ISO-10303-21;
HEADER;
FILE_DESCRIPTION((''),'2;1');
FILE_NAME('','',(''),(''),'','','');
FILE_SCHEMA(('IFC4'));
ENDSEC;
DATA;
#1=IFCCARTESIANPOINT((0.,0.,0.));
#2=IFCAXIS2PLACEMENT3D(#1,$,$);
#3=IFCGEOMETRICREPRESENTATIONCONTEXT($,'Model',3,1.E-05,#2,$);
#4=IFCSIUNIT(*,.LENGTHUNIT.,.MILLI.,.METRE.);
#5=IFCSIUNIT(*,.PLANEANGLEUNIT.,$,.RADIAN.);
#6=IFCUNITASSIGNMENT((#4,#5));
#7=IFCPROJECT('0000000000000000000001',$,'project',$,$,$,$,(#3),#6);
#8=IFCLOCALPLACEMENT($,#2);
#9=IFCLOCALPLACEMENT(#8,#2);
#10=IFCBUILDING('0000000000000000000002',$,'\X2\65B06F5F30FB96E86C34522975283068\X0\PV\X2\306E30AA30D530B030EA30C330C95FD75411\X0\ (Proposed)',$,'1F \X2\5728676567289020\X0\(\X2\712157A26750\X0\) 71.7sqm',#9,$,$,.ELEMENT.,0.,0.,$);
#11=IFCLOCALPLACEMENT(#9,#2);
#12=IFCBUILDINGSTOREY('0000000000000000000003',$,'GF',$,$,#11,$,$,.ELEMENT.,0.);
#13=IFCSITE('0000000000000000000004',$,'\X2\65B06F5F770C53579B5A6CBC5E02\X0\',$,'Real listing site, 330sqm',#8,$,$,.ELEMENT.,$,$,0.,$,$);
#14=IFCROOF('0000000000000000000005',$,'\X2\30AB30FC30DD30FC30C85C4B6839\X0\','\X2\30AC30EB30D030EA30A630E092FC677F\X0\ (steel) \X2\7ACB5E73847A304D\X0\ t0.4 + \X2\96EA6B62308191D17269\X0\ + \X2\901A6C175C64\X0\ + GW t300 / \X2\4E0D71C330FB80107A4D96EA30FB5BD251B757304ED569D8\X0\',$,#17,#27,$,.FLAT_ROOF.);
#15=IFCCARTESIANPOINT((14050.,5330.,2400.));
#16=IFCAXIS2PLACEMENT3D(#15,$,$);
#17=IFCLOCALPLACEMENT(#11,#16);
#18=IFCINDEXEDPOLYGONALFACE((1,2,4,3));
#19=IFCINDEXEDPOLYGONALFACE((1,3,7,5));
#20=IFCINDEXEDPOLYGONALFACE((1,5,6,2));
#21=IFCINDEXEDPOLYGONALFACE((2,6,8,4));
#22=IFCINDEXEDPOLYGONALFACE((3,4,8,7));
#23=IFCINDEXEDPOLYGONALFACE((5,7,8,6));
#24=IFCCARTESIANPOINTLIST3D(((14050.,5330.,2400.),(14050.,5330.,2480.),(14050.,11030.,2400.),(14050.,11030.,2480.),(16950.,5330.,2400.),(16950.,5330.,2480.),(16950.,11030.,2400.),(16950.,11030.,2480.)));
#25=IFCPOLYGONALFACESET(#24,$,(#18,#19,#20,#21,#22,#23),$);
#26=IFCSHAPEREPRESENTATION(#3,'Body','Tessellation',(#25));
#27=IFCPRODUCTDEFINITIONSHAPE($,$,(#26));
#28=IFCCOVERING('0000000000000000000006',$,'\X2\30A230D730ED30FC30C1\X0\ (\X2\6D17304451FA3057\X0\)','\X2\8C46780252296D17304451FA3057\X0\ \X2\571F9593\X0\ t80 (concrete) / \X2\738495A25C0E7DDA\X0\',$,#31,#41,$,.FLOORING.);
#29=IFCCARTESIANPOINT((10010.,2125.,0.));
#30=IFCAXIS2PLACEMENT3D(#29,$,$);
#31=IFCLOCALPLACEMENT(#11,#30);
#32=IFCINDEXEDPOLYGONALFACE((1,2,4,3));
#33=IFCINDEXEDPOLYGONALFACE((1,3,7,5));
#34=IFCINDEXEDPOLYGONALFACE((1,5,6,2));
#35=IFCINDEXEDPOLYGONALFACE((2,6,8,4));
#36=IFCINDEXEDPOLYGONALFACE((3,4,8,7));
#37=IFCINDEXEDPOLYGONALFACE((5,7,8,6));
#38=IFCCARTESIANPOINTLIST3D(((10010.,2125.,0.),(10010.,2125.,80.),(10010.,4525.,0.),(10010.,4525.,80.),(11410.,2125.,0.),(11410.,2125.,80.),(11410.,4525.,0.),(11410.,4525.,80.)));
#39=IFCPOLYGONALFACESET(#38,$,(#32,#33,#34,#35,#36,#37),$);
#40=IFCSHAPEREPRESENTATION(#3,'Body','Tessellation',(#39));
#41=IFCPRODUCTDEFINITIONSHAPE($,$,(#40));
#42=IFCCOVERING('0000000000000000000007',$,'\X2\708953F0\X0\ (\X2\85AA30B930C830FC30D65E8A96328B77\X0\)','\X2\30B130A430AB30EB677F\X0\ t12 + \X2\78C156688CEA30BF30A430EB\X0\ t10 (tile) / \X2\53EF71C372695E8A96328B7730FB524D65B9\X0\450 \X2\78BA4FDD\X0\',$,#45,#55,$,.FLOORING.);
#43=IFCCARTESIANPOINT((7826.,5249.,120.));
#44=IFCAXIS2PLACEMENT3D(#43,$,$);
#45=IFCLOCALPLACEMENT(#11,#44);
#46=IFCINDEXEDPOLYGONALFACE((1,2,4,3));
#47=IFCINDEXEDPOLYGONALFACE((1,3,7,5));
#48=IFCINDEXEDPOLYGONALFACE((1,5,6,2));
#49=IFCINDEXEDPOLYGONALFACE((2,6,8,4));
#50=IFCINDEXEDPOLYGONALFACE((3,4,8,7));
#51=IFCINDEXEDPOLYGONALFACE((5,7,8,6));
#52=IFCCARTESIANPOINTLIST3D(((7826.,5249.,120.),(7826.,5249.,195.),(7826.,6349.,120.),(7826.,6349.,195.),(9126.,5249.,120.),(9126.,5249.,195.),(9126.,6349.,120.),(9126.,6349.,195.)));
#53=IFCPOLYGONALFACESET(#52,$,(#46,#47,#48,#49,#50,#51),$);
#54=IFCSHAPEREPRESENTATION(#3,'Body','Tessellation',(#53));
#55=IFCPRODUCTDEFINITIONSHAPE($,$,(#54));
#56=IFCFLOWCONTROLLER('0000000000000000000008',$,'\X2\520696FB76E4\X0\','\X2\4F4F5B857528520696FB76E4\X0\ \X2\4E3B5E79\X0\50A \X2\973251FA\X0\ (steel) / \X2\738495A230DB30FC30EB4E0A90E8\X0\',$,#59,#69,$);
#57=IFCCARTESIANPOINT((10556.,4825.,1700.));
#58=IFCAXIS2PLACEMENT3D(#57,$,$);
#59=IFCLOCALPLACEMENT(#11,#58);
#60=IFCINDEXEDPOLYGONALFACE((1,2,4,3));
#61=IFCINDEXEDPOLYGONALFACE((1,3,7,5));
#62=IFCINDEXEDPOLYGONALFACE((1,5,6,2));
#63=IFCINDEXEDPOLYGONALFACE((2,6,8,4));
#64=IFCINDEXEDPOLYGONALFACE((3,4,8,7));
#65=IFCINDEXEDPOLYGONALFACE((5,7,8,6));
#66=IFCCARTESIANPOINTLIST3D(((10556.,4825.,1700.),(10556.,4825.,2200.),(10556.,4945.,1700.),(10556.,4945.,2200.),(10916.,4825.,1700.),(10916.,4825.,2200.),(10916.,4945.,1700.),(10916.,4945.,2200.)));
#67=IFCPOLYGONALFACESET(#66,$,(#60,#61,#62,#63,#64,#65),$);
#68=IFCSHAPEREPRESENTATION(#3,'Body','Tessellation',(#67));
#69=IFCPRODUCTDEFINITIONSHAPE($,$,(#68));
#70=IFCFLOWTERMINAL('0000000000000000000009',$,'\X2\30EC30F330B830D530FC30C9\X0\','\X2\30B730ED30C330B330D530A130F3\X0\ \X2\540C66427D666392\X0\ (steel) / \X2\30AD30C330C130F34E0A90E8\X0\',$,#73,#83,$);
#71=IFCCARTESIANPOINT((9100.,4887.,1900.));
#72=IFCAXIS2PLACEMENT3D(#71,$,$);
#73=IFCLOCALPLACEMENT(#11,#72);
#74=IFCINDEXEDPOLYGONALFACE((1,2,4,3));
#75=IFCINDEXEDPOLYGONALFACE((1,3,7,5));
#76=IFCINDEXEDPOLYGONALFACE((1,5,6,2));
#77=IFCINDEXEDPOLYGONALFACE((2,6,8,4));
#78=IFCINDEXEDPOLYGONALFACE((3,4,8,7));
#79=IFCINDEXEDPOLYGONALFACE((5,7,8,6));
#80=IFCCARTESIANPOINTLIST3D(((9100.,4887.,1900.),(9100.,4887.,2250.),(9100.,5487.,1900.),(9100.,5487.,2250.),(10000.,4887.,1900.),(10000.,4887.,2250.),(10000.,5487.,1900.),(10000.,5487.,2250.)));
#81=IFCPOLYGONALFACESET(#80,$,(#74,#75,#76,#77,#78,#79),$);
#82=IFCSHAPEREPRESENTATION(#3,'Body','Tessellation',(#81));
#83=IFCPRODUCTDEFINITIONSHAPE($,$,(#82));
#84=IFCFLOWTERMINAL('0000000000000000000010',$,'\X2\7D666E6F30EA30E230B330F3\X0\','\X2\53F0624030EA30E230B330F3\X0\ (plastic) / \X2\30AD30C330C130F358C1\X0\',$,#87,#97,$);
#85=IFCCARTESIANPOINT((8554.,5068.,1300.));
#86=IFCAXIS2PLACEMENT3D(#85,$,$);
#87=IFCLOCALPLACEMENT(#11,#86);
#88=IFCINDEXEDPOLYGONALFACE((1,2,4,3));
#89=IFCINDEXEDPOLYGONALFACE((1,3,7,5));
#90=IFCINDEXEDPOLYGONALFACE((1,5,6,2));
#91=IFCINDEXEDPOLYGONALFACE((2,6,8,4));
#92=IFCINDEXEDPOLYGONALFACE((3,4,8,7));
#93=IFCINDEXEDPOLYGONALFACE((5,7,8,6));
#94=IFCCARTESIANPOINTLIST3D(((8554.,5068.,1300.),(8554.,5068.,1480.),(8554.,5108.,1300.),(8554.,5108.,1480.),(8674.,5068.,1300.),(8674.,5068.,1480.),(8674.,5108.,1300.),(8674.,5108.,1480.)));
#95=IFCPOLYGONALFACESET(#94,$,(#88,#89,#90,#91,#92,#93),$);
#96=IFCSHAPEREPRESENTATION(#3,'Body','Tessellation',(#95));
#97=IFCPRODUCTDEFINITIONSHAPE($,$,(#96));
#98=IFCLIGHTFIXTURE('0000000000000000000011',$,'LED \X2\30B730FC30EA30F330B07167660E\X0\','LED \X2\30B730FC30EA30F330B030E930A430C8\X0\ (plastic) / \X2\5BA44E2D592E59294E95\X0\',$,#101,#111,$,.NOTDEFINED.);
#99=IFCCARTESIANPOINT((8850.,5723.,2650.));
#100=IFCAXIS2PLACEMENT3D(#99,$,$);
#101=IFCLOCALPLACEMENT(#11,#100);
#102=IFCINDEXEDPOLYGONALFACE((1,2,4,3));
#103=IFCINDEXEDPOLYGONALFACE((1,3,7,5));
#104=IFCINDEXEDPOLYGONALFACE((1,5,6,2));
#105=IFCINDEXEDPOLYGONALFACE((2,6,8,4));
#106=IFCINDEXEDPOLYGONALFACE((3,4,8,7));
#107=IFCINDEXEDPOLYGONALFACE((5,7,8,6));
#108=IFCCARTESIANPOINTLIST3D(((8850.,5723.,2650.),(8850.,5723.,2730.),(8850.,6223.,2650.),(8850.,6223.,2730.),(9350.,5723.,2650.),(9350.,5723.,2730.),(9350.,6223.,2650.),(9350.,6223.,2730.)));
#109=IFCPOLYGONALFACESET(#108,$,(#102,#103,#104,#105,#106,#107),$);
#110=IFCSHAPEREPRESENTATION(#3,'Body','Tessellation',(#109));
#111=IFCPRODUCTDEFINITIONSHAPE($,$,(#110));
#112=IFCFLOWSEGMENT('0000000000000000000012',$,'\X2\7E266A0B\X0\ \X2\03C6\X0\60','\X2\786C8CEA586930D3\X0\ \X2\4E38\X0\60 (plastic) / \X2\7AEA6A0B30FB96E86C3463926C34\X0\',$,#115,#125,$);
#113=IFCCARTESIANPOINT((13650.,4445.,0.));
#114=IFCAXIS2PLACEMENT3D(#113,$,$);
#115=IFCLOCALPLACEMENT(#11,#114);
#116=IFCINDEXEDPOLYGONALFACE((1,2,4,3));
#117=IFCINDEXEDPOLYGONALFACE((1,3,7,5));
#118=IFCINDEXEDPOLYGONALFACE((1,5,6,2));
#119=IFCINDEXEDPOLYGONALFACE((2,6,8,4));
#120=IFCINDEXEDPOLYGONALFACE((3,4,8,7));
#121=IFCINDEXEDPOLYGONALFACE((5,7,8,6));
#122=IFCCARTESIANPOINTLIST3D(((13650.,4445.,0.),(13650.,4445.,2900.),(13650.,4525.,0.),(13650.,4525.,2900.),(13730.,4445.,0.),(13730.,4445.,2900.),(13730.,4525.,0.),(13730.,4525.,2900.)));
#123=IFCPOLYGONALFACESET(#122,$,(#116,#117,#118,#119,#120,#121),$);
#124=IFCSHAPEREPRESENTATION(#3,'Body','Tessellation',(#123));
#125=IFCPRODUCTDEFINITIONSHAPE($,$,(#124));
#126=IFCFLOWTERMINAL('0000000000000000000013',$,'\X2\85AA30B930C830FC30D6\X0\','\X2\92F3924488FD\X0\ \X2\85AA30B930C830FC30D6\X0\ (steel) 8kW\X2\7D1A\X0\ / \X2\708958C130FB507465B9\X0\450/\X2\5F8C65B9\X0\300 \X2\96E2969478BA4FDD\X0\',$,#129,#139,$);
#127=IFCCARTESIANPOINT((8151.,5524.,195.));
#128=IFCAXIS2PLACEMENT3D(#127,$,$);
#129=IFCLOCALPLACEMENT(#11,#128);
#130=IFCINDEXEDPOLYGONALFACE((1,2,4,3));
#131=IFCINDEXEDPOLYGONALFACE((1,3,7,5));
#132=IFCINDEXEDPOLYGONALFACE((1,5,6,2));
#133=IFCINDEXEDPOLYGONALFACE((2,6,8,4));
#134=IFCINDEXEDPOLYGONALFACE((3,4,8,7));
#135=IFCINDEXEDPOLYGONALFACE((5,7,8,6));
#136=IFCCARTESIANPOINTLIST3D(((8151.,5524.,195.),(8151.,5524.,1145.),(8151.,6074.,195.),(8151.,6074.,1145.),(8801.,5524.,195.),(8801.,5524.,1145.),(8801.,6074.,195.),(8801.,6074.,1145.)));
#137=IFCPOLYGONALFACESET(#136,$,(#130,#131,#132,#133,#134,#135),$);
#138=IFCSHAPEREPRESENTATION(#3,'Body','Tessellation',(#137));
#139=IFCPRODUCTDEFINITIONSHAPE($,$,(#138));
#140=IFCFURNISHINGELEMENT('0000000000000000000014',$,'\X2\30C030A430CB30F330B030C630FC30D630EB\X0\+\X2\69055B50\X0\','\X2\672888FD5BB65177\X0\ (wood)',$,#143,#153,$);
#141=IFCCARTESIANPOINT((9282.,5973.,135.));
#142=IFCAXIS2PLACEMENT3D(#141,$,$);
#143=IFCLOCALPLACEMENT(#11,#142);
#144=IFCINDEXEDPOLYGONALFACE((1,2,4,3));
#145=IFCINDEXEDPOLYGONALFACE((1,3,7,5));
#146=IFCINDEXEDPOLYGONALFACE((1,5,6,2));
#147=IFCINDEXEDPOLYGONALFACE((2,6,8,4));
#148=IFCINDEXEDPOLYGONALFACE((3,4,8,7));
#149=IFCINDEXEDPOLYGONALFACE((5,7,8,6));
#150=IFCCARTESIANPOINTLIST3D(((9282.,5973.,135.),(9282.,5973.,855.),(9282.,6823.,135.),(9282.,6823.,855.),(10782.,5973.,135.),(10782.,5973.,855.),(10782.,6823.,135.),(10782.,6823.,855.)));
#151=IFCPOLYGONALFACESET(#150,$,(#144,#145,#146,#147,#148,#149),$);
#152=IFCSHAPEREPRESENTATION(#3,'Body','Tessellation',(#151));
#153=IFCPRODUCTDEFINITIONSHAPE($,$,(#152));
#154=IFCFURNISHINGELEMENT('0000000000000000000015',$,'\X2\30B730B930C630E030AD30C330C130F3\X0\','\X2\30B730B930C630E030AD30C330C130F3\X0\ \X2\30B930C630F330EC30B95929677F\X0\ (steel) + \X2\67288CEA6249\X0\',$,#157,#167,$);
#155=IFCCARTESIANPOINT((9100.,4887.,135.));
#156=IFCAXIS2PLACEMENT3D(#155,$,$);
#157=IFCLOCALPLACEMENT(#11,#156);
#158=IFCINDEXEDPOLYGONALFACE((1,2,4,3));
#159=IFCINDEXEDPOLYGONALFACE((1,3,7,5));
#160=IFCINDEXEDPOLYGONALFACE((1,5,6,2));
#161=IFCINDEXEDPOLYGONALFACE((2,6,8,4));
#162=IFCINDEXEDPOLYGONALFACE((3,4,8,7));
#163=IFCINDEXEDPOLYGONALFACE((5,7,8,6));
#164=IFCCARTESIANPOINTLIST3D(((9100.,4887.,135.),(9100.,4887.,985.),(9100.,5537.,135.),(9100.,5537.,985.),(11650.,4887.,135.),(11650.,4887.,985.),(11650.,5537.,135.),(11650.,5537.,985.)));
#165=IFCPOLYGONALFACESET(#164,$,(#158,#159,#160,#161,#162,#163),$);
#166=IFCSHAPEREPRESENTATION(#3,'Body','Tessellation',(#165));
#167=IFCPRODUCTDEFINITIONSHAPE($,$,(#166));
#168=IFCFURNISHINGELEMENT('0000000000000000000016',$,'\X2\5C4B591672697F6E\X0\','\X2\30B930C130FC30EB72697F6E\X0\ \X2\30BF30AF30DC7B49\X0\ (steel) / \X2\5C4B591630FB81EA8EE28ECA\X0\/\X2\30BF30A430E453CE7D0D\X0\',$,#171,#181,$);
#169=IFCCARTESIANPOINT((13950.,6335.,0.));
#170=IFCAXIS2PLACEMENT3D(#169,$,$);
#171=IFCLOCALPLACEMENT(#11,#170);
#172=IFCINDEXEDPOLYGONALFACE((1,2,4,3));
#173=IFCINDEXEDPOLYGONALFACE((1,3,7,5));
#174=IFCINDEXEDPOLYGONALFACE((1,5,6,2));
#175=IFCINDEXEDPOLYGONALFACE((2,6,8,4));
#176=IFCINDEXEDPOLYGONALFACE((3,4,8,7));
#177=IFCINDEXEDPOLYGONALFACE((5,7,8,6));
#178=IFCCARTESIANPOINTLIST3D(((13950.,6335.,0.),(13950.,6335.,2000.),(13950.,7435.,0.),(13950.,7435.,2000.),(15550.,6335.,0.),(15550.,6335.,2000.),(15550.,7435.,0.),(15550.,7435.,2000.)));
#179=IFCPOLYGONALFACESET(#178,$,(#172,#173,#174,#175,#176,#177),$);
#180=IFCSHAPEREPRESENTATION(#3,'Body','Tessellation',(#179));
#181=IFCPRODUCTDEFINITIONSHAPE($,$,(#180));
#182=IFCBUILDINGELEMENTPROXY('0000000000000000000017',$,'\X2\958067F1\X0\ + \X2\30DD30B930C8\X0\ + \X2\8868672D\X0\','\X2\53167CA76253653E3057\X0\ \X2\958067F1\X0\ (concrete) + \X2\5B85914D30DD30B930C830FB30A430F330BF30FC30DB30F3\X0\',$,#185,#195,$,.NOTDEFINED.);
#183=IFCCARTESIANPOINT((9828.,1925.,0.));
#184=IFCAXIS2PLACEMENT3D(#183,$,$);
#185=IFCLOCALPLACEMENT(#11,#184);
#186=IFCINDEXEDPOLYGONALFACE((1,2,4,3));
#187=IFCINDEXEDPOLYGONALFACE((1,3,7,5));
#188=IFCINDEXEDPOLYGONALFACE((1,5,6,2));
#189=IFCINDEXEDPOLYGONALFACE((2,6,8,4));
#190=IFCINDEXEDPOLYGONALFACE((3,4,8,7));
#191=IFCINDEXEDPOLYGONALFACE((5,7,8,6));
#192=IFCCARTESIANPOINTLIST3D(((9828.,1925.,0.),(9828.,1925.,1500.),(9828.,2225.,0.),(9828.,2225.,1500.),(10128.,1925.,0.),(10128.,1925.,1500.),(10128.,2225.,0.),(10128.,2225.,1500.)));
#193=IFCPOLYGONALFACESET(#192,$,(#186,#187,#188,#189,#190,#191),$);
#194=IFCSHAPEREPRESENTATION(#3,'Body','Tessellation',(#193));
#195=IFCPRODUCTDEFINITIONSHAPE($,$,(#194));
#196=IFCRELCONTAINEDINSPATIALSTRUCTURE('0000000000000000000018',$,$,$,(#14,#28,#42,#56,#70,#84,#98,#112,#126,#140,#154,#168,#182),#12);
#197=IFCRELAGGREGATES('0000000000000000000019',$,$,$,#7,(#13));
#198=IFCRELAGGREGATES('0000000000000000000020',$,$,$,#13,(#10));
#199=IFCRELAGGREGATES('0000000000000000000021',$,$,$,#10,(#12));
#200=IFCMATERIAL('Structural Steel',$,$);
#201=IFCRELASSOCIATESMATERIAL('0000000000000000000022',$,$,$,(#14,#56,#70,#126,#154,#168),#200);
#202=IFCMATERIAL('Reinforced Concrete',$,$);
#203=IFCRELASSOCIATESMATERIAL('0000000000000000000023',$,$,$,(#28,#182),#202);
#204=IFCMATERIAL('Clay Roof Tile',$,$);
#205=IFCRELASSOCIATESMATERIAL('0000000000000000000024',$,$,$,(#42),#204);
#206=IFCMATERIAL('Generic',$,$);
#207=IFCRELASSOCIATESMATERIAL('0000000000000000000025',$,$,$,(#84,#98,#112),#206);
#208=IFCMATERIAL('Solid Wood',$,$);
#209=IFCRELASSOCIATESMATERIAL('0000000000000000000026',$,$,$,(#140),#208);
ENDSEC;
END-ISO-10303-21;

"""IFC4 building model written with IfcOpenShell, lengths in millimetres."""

from ifc_helpers import new_model, si_unit, frame, frame_2d, origin, place, context, project, spatial, rectangle, extrude, material, element, save


model = new_model("IFC4")

# Units and contexts
model_context = context("Model", 3, precision=1e-05, world=origin())
ifc_project = project(units=[si_unit("LENGTHUNIT", "METRE", prefix="MILLI"), si_unit("PLANEANGLEUNIT", "RADIAN")], contexts=[model_context])

# Site, building, storey
site_placement = place(None, origin())
site = spatial("IfcSite", under=ifc_project, at=site_placement, Name="新潟県南魚沼市", ObjectType="Real listing site, 330sqm", CompositionType="ELEMENT", RefElevation=0.0)
building_placement = place(site_placement, origin())
building = spatial("IfcBuilding", under=site, at=building_placement, Name="新潟・雨水利用とPVのオフグリッド志向 (Proposed)", ObjectType="1F 在来木造(無垢材) 71.7sqm", CompositionType="ELEMENT", ElevationOfRefHeight=0.0, ElevationOfTerrain=0.0)
storey_placement = place(building_placement, origin())
storey = spatial("IfcBuildingStorey", under=building, at=storey_placement, Name="GF", CompositionType="ELEMENT", Elevation=0.0)

# Shared definitions
ifc_material_1 = material(Name="Solid Wood")
ifc_material_2 = material(Name="Structural Steel")

# Shared definitions
ifc_material_3 = material(Name="Reinforced Concrete")

# Roof
roof_1_placement = place(storey_placement, frame((14050.0, 5330.0, 2400.0)))
element("IfcRoof", 1, at=roof_1_placement, inside=storey, material=ifc_material_2, Name="カーポート屋根", Description="ガルバリウム鋼板 (steel) 立平葺き t0.4 + 雪止め金物 + 通気層 + GW t300 / 不燃・耐積雪・寒冷地仕様", PredefinedType="FLAT_ROOF", context=model_context, shape_type="SweptSolid", body=[
    extrude(rectangle(XDim=2900.0, YDim=5700.0, at=frame_2d((1450.0, 2850.0))), frame((14050.0, 5330.0, 2400.0)), (0.0, 0.0, 1.0), 80.0),
])

# Coverings
covering_1_placement = place(storey_placement, frame((10010.0, 2125.0, 0.0)))
element("IfcCovering", 2, at=covering_1_placement, inside=storey, material=ifc_material_3, Name="アプローチ (洗い出し)", Description="豆砂利洗い出し 土間 t80 (concrete) / 玄関導線", PredefinedType="FLOORING", context=model_context, shape_type="SweptSolid", body=[
    extrude(rectangle(XDim=1400.0, YDim=2400.0, at=frame_2d((700.0, 1200.0))), frame((10010.0, 2125.0, 0.0)), (0.0, 0.0, 1.0), 80.0),
])
ifc_material_4 = material(Name="Clay Roof Tile")
covering_2_placement = place(storey_placement, frame((7826.0, 5249.0, 120.0)))
element("IfcCovering", 3, at=covering_2_placement, inside=storey, material=ifc_material_4, Name="炉台 (薪ストーブ床防護)", Description="ケイカル板 t12 + 磁器質タイル t10 (tile) / 可燃物床防護・前方450 確保", PredefinedType="FLOORING", context=model_context, shape_type="SweptSolid", body=[
    extrude(rectangle(XDim=1300.0, YDim=1100.0, at=frame_2d((650.0, 550.0))), frame((7826.0, 5249.0, 120.0)), (0.0, 0.0, 1.0), 75.0),
])

# Flow controller
flow_controller_placement = place(storey_placement, frame((10556.0, 4825.0, 1700.0)))
element("IfcFlowController", 4, at=flow_controller_placement, inside=storey, material=ifc_material_2, Name="分電盤", Description="住宅用分電盤 主幹50A 露出 (steel) / 玄関ホール上部", context=model_context, shape_type="SweptSolid", body=[
    extrude(rectangle(XDim=360.0, YDim=120.0, at=frame_2d((180.0, 60.0))), frame((10556.0, 4825.0, 1700.0)), (0.0, 0.0, 1.0), 500.0),
])

# Flow terminals
flow_terminal_1_placement = place(storey_placement, frame((9100.0, 4887.0, 1900.0)))
element("IfcFlowTerminal", 5, at=flow_terminal_1_placement, inside=storey, material=ifc_material_2, Name="レンジフード", Description="シロッコファン 同時給排 (steel) / キッチン上部", context=model_context, shape_type="SweptSolid", body=[
    extrude(rectangle(XDim=900.0, YDim=600.0, at=frame_2d((450.0, 300.0))), frame((9100.0, 4887.0, 1900.0)), (0.0, 0.0, 1.0), 350.0),
])
ifc_material_5 = material(Name="Generic")
flow_terminal_2_placement = place(storey_placement, frame((8554.0, 5068.0, 1300.0)))
element("IfcFlowTerminal", 6, at=flow_terminal_2_placement, inside=storey, material=ifc_material_5, Name="給湯リモコン", Description="台所リモコン (plastic) / キッチン壁", context=model_context, shape_type="SweptSolid", body=[
    extrude(rectangle(XDim=120.0, YDim=40.0, at=frame_2d((60.0, 20.0))), frame((8554.0, 5068.0, 1300.0)), (0.0, 0.0, 1.0), 180.0),
])

# Light fixture
light_fixture_placement = place(storey_placement, frame((8850.0, 5723.0, 2650.0)))
element("IfcLightFixture", 7, at=light_fixture_placement, inside=storey, material=ifc_material_5, Name="LED シーリング照明", Description="LED シーリングライト (plastic) / 室中央天井", PredefinedType="NOTDEFINED", context=model_context, shape_type="SweptSolid", body=[
    extrude(rectangle(XDim=500.0, YDim=500.0, at=frame_2d((250.0, 250.0))), frame((8850.0, 5723.0, 2650.0)), (0.0, 0.0, 1.0), 80.0),
])

# Flow segment
flow_segment_placement = place(storey_placement, frame((13650.0, 4445.0, 0.0)))
element("IfcFlowSegment", 8, at=flow_segment_placement, inside=storey, material=ifc_material_5, Name="縦樋 φ60", Description="硬質塩ビ 丸60 (plastic) / 竪樋・雨水排水", context=model_context, shape_type="SweptSolid", body=[
    extrude(rectangle(XDim=80.0, YDim=80.0, at=frame_2d((40.0, 40.0))), frame((13650.0, 4445.0, 0.0)), (0.0, 0.0, 1.0), 2900.0),
])

# Flow terminal
flow_terminal_3_placement = place(storey_placement, frame((8151.0, 5524.0, 195.0)))
element("IfcFlowTerminal", 9, at=flow_terminal_3_placement, inside=storey, material=ifc_material_2, Name="薪ストーブ", Description="鋳鉄製 薪ストーブ (steel) 8kW級 / 炉壁・側方450/後方300 離隔確保", context=model_context, shape_type="SweptSolid", body=[
    extrude(rectangle(XDim=650.0, YDim=550.0, at=frame_2d((325.0, 275.0))), frame((8151.0, 5524.0, 195.0)), (0.0, 0.0, 1.0), 950.0),
])

# Furnishing elements
furnishing_1_placement = place(storey_placement, frame((9282.0, 5973.0, 135.0)))
element("IfcFurnishingElement", 10, at=furnishing_1_placement, inside=storey, material=ifc_material_1, Name="ダイニングテーブル+椅子", Description="木製家具 (wood)", context=model_context, shape_type="SweptSolid", body=[
    extrude(rectangle(XDim=1500.0, YDim=850.0, at=frame_2d((750.0, 425.0))), frame((9282.0, 5973.0, 135.0)), (0.0, 0.0, 1.0), 720.0),
])
furnishing_2_placement = place(storey_placement, frame((9100.0, 4887.0, 135.0)))
element("IfcFurnishingElement", 11, at=furnishing_2_placement, inside=storey, material=ifc_material_2, Name="システムキッチン", Description="システムキッチン ステンレス天板 (steel) + 木質扉", context=model_context, shape_type="SweptSolid", body=[
    extrude(rectangle(XDim=2550.0, YDim=650.0, at=frame_2d((1275.0, 325.0))), frame((9100.0, 4887.0, 135.0)), (0.0, 0.0, 1.0), 850.0),
])
furnishing_3_placement = place(storey_placement, frame((13950.0, 6335.0, 0.0)))
element("IfcFurnishingElement", 12, at=furnishing_3_placement, inside=storey, material=ifc_material_2, Name="屋外物置", Description="スチール物置 タクボ等 (steel) / 屋外・自転車/タイヤ収納", context=model_context, shape_type="SweptSolid", body=[
    extrude(rectangle(XDim=1600.0, YDim=1100.0, at=frame_2d((800.0, 550.0))), frame((13950.0, 6335.0, 0.0)), (0.0, 0.0, 1.0), 2000.0),
])

# Building element proxy
proxy_placement = place(storey_placement, frame((9828.0, 1925.0, 0.0)))
element("IfcBuildingElementProxy", 13, at=proxy_placement, inside=storey, material=ifc_material_3, Name="門柱 + ポスト + 表札", Description="化粧打放し 門柱 (concrete) + 宅配ポスト・インターホン", PredefinedType="NOTDEFINED", context=model_context, shape_type="SweptSolid", body=[
    extrude(rectangle(XDim=300.0, YDim=300.0, at=frame_2d((150.0, 150.0))), frame((9828.0, 1925.0, 0.0)), (0.0, 0.0, 1.0), 1500.0),
])

save(model, "model.ifc")
